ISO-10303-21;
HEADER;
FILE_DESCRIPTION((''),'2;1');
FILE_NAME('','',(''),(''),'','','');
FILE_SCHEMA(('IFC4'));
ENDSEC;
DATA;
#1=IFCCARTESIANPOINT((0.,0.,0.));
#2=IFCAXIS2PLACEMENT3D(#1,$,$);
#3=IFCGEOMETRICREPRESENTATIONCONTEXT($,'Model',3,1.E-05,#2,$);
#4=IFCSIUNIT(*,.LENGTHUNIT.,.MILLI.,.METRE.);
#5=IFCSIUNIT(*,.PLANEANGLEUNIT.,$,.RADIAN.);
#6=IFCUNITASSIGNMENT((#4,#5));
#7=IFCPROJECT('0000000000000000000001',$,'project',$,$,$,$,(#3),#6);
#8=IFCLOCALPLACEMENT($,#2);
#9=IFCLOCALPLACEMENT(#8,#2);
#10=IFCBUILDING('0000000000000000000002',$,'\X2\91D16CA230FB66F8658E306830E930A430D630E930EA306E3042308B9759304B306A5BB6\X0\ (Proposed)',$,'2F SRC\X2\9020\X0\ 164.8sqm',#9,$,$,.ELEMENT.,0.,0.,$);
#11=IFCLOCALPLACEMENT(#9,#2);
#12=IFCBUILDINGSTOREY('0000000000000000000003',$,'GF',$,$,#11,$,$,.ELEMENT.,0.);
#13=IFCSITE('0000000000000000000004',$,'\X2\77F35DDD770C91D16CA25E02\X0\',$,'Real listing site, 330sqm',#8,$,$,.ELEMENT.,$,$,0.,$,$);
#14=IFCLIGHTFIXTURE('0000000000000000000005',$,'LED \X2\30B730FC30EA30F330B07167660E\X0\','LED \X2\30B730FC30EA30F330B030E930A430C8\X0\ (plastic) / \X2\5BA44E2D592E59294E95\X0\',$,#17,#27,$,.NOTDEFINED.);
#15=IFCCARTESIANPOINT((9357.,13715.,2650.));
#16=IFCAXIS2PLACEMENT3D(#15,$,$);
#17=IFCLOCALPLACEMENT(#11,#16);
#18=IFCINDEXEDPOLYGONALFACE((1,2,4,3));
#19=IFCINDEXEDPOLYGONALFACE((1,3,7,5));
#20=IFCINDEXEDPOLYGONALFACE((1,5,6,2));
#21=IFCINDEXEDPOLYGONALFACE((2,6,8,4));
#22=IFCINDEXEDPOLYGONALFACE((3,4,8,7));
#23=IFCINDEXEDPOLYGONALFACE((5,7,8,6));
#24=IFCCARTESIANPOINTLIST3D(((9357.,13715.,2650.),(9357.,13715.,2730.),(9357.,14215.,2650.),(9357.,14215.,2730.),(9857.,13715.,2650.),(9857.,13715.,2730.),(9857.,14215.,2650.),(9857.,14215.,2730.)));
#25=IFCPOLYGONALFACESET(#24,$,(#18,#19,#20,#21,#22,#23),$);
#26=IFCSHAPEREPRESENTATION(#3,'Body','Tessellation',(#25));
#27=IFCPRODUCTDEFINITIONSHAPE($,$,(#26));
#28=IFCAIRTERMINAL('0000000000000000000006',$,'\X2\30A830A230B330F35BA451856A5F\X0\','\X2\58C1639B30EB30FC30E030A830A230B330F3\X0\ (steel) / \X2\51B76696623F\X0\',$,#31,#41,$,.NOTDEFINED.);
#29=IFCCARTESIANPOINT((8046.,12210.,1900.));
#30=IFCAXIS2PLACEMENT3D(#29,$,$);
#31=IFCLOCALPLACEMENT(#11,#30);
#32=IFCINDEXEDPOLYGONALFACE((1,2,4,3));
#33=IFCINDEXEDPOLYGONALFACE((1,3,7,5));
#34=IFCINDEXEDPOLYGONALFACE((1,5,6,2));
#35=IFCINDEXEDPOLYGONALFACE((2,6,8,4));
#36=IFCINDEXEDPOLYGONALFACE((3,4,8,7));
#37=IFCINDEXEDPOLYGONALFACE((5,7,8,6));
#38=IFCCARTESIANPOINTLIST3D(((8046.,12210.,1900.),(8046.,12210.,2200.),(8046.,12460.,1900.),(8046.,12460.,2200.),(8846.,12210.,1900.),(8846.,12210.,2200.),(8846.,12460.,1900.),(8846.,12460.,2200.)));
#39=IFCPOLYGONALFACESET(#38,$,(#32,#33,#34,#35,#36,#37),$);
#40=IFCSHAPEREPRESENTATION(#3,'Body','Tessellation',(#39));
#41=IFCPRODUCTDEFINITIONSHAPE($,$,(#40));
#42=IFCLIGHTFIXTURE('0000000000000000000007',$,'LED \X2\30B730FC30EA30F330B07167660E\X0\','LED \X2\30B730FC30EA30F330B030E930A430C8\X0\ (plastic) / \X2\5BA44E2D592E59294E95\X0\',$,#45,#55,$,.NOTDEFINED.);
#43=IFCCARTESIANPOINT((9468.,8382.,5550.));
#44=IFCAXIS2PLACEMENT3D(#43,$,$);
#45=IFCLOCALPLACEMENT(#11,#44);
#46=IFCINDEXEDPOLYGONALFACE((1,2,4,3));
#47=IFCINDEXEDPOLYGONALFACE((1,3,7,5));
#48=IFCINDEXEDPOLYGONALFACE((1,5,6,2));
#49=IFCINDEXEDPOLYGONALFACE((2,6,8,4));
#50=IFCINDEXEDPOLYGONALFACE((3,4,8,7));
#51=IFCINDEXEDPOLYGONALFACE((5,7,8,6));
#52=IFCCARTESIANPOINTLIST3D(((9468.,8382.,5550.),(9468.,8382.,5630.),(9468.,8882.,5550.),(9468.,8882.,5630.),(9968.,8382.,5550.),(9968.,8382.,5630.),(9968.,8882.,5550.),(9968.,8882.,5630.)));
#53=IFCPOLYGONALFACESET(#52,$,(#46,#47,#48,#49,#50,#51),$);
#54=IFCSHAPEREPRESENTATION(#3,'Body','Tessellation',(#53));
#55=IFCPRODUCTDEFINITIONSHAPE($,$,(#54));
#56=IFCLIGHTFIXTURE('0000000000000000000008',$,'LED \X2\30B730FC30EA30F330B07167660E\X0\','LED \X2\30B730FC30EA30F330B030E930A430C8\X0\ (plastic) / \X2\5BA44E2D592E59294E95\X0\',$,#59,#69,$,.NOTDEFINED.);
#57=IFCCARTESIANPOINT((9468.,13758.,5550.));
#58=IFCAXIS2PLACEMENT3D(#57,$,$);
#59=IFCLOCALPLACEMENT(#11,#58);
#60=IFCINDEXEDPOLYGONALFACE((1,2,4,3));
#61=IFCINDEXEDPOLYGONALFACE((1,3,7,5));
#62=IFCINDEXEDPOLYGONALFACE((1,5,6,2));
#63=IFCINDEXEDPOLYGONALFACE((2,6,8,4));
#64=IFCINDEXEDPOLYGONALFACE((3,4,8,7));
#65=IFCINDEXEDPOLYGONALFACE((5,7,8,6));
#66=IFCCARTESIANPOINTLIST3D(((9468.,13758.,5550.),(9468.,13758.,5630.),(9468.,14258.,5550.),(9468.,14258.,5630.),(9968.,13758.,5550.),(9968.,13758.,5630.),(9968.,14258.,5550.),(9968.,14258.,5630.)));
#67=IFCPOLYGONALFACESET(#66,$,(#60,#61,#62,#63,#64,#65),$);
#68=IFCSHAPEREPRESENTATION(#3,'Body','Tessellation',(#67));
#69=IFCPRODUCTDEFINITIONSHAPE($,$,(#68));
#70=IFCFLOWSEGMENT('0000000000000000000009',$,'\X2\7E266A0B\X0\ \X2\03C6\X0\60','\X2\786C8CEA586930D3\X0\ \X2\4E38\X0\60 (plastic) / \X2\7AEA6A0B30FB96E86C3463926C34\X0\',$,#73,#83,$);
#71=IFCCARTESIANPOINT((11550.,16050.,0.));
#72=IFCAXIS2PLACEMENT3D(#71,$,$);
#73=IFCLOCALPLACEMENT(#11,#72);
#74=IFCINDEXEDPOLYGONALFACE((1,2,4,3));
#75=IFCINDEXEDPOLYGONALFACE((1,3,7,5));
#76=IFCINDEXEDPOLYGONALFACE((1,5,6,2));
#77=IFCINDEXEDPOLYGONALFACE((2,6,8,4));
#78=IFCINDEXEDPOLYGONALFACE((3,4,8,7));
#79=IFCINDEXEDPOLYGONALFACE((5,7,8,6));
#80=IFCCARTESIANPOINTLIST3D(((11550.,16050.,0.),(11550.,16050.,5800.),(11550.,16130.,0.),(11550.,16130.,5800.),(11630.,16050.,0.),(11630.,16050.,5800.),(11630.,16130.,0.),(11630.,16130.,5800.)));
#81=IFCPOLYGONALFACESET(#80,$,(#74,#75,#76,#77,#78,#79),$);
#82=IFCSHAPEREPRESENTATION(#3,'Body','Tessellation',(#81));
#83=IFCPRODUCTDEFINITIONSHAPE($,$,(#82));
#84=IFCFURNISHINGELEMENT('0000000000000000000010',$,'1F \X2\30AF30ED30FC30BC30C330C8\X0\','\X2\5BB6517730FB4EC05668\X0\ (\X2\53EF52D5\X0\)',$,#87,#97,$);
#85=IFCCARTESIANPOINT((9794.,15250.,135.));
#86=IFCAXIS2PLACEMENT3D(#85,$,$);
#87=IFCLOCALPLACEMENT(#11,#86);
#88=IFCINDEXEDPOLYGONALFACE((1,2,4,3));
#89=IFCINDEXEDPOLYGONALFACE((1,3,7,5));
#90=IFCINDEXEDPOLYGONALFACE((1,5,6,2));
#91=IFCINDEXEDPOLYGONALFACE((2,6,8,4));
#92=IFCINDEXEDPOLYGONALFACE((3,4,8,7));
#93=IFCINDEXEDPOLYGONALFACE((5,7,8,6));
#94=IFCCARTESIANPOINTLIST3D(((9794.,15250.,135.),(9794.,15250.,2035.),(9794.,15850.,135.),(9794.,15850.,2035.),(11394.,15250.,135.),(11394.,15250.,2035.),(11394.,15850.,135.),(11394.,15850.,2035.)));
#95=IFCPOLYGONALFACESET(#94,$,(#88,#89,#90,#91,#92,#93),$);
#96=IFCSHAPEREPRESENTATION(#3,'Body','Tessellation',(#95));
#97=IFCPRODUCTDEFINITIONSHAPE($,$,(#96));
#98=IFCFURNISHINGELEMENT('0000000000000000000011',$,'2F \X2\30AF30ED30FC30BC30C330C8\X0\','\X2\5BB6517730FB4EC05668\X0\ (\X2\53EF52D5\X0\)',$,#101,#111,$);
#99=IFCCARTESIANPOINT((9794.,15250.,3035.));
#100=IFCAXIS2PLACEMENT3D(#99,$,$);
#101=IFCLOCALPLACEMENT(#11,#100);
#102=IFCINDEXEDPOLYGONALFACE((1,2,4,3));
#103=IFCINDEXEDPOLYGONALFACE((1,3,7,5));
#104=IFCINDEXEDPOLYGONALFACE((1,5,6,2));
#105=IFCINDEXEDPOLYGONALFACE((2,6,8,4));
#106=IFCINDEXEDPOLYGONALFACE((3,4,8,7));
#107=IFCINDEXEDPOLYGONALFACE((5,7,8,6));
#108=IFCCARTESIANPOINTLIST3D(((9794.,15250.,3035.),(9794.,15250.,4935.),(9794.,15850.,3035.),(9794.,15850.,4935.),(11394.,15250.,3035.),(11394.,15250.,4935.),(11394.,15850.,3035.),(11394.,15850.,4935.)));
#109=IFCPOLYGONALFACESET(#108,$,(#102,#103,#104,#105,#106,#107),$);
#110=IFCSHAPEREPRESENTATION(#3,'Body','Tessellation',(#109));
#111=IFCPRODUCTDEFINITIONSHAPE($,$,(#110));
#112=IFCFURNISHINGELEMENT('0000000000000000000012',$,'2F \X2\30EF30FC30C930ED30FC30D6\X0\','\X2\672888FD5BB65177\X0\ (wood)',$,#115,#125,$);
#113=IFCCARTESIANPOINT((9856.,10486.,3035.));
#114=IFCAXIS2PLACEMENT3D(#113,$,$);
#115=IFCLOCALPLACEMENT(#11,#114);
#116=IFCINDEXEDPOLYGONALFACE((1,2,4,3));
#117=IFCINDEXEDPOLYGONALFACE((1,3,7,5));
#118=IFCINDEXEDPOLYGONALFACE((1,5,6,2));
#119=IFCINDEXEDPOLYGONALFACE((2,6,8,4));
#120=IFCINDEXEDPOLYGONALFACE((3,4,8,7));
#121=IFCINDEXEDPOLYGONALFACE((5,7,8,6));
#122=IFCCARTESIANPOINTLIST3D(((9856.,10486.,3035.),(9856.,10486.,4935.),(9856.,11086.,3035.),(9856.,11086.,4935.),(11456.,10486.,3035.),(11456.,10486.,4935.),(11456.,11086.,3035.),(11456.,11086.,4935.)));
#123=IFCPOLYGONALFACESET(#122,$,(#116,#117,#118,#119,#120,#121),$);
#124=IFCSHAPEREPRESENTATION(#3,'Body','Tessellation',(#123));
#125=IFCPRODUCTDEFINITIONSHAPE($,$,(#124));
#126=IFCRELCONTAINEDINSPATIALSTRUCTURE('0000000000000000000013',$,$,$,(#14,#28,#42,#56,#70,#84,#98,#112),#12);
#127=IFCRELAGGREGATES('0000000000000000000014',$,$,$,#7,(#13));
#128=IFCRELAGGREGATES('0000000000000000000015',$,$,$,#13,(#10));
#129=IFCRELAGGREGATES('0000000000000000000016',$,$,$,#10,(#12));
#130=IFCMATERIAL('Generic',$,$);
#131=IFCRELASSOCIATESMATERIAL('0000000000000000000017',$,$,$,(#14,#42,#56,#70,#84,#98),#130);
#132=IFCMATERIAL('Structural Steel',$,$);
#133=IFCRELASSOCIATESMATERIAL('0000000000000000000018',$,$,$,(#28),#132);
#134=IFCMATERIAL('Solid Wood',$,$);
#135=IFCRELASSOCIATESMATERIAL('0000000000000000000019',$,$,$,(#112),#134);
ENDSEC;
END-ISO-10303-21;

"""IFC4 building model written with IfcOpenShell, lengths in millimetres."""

from ifc_helpers import new_model, si_unit, frame, frame_2d, origin, place, context, project, spatial, rectangle, extrude, material, element, save


model = new_model("IFC4")

# Units and contexts
model_context = context("Model", 3, precision=1e-05, world=origin())
ifc_project = project(units=[si_unit("LENGTHUNIT", "METRE", prefix="MILLI"), si_unit("PLANEANGLEUNIT", "RADIAN")], contexts=[model_context])

# Site, building, storey
site_placement = place(None, origin())
site = spatial("IfcSite", under=ifc_project, at=site_placement, Name="石川県金沢市", ObjectType="Real listing site, 330sqm", CompositionType="ELEMENT", RefElevation=0.0)
building_placement = place(site_placement, origin())
building = spatial("IfcBuilding", under=site, at=building_placement, Name="金沢・書斎とライブラリのある静かな家 (Proposed)", ObjectType="2F SRC造 164.8sqm", CompositionType="ELEMENT", ElevationOfRefHeight=0.0, ElevationOfTerrain=0.0)
storey_placement = place(building_placement, origin())
storey = spatial("IfcBuildingStorey", under=building, at=storey_placement, Name="GF", CompositionType="ELEMENT", Elevation=0.0)

# Shared definitions
ifc_material_1 = material(Name="Solid Wood")

# Shared definitions
ifc_material_2 = material(Name="Structural Steel")

# Shared definitions
ifc_material_3 = material(Name="Generic")

# Light fixture
light_fixture_1_placement = place(storey_placement, frame((9357.0, 13715.0, 2650.0)))
element("IfcLightFixture", 1, at=light_fixture_1_placement, inside=storey, material=ifc_material_3, Name="LED シーリング照明", Description="LED シーリングライト (plastic) / 室中央天井", PredefinedType="NOTDEFINED", context=model_context, shape_type="SweptSolid", body=[
    extrude(rectangle(XDim=500.0, YDim=500.0, at=frame_2d((250.0, 250.0))), frame((9357.0, 13715.0, 2650.0)), (0.0, 0.0, 1.0), 80.0),
])

# Air terminal
air_terminal_placement = place(storey_placement, frame((8046.0, 12210.0, 1900.0)))
element("IfcAirTerminal", 2, at=air_terminal_placement, inside=storey, material=ifc_material_2, Name="エアコン室内機", Description="壁掛ルームエアコン (steel) / 冷暖房", PredefinedType="NOTDEFINED", context=model_context, shape_type="SweptSolid", body=[
    extrude(rectangle(XDim=800.0, YDim=250.0, at=frame_2d((400.0, 125.0))), frame((8046.0, 12210.0, 1900.0)), (0.0, 0.0, 1.0), 300.0),
])

# Light fixtures
light_fixture_2_placement = place(storey_placement, frame((9468.0, 8382.0, 5550.0)))
element("IfcLightFixture", 3, at=light_fixture_2_placement, inside=storey, material=ifc_material_3, Name="LED シーリング照明", Description="LED シーリングライト (plastic) / 室中央天井", PredefinedType="NOTDEFINED", context=model_context, shape_type="SweptSolid", body=[
    extrude(rectangle(XDim=500.0, YDim=500.0, at=frame_2d((250.0, 250.0))), frame((9468.0, 8382.0, 5550.0)), (0.0, 0.0, 1.0), 80.0),
])
light_fixture_3_placement = place(storey_placement, frame((9468.0, 13758.0, 5550.0)))
element("IfcLightFixture", 4, at=light_fixture_3_placement, inside=storey, material=ifc_material_3, Name="LED シーリング照明", Description="LED シーリングライト (plastic) / 室中央天井", PredefinedType="NOTDEFINED", context=model_context, shape_type="SweptSolid", body=[
    extrude(rectangle(XDim=500.0, YDim=500.0, at=frame_2d((250.0, 250.0))), frame((9468.0, 13758.0, 5550.0)), (0.0, 0.0, 1.0), 80.0),
])

# Flow segment
flow_segment_placement = place(storey_placement, frame((11550.0, 16050.0, 0.0)))
element("IfcFlowSegment", 5, at=flow_segment_placement, inside=storey, material=ifc_material_3, Name="縦樋 φ60", Description="硬質塩ビ 丸60 (plastic) / 竪樋・雨水排水", context=model_context, shape_type="SweptSolid", body=[
    extrude(rectangle(XDim=80.0, YDim=80.0, at=frame_2d((40.0, 40.0))), frame((11550.0, 16050.0, 0.0)), (0.0, 0.0, 1.0), 5800.0),
])

# Furnishing elements
furnishing_1_placement = place(storey_placement, frame((9794.0, 15250.0, 135.0)))
element("IfcFurnishingElement", 6, at=furnishing_1_placement, inside=storey, material=ifc_material_3, Name="1F クローゼット", Description="家具・什器 (可動)", context=model_context, shape_type="SweptSolid", body=[
    extrude(rectangle(XDim=1600.0, YDim=600.0, at=frame_2d((800.0, 300.0))), frame((9794.0, 15250.0, 135.0)), (0.0, 0.0, 1.0), 1900.0),
])
furnishing_2_placement = place(storey_placement, frame((9794.0, 15250.0, 3035.0)))
element("IfcFurnishingElement", 7, at=furnishing_2_placement, inside=storey, material=ifc_material_3, Name="2F クローゼット", Description="家具・什器 (可動)", context=model_context, shape_type="SweptSolid", body=[
    extrude(rectangle(XDim=1600.0, YDim=600.0, at=frame_2d((800.0, 300.0))), frame((9794.0, 15250.0, 3035.0)), (0.0, 0.0, 1.0), 1900.0),
])
furnishing_3_placement = place(storey_placement, frame((9856.0, 10486.0, 3035.0)))
element("IfcFurnishingElement", 8, at=furnishing_3_placement, inside=storey, material=ifc_material_1, Name="2F ワードローブ", Description="木製家具 (wood)", context=model_context, shape_type="SweptSolid", body=[
    extrude(rectangle(XDim=1600.0, YDim=600.0, at=frame_2d((800.0, 300.0))), frame((9856.0, 10486.0, 3035.0)), (0.0, 0.0, 1.0), 1900.0),
])

save(model, "model.ifc")
